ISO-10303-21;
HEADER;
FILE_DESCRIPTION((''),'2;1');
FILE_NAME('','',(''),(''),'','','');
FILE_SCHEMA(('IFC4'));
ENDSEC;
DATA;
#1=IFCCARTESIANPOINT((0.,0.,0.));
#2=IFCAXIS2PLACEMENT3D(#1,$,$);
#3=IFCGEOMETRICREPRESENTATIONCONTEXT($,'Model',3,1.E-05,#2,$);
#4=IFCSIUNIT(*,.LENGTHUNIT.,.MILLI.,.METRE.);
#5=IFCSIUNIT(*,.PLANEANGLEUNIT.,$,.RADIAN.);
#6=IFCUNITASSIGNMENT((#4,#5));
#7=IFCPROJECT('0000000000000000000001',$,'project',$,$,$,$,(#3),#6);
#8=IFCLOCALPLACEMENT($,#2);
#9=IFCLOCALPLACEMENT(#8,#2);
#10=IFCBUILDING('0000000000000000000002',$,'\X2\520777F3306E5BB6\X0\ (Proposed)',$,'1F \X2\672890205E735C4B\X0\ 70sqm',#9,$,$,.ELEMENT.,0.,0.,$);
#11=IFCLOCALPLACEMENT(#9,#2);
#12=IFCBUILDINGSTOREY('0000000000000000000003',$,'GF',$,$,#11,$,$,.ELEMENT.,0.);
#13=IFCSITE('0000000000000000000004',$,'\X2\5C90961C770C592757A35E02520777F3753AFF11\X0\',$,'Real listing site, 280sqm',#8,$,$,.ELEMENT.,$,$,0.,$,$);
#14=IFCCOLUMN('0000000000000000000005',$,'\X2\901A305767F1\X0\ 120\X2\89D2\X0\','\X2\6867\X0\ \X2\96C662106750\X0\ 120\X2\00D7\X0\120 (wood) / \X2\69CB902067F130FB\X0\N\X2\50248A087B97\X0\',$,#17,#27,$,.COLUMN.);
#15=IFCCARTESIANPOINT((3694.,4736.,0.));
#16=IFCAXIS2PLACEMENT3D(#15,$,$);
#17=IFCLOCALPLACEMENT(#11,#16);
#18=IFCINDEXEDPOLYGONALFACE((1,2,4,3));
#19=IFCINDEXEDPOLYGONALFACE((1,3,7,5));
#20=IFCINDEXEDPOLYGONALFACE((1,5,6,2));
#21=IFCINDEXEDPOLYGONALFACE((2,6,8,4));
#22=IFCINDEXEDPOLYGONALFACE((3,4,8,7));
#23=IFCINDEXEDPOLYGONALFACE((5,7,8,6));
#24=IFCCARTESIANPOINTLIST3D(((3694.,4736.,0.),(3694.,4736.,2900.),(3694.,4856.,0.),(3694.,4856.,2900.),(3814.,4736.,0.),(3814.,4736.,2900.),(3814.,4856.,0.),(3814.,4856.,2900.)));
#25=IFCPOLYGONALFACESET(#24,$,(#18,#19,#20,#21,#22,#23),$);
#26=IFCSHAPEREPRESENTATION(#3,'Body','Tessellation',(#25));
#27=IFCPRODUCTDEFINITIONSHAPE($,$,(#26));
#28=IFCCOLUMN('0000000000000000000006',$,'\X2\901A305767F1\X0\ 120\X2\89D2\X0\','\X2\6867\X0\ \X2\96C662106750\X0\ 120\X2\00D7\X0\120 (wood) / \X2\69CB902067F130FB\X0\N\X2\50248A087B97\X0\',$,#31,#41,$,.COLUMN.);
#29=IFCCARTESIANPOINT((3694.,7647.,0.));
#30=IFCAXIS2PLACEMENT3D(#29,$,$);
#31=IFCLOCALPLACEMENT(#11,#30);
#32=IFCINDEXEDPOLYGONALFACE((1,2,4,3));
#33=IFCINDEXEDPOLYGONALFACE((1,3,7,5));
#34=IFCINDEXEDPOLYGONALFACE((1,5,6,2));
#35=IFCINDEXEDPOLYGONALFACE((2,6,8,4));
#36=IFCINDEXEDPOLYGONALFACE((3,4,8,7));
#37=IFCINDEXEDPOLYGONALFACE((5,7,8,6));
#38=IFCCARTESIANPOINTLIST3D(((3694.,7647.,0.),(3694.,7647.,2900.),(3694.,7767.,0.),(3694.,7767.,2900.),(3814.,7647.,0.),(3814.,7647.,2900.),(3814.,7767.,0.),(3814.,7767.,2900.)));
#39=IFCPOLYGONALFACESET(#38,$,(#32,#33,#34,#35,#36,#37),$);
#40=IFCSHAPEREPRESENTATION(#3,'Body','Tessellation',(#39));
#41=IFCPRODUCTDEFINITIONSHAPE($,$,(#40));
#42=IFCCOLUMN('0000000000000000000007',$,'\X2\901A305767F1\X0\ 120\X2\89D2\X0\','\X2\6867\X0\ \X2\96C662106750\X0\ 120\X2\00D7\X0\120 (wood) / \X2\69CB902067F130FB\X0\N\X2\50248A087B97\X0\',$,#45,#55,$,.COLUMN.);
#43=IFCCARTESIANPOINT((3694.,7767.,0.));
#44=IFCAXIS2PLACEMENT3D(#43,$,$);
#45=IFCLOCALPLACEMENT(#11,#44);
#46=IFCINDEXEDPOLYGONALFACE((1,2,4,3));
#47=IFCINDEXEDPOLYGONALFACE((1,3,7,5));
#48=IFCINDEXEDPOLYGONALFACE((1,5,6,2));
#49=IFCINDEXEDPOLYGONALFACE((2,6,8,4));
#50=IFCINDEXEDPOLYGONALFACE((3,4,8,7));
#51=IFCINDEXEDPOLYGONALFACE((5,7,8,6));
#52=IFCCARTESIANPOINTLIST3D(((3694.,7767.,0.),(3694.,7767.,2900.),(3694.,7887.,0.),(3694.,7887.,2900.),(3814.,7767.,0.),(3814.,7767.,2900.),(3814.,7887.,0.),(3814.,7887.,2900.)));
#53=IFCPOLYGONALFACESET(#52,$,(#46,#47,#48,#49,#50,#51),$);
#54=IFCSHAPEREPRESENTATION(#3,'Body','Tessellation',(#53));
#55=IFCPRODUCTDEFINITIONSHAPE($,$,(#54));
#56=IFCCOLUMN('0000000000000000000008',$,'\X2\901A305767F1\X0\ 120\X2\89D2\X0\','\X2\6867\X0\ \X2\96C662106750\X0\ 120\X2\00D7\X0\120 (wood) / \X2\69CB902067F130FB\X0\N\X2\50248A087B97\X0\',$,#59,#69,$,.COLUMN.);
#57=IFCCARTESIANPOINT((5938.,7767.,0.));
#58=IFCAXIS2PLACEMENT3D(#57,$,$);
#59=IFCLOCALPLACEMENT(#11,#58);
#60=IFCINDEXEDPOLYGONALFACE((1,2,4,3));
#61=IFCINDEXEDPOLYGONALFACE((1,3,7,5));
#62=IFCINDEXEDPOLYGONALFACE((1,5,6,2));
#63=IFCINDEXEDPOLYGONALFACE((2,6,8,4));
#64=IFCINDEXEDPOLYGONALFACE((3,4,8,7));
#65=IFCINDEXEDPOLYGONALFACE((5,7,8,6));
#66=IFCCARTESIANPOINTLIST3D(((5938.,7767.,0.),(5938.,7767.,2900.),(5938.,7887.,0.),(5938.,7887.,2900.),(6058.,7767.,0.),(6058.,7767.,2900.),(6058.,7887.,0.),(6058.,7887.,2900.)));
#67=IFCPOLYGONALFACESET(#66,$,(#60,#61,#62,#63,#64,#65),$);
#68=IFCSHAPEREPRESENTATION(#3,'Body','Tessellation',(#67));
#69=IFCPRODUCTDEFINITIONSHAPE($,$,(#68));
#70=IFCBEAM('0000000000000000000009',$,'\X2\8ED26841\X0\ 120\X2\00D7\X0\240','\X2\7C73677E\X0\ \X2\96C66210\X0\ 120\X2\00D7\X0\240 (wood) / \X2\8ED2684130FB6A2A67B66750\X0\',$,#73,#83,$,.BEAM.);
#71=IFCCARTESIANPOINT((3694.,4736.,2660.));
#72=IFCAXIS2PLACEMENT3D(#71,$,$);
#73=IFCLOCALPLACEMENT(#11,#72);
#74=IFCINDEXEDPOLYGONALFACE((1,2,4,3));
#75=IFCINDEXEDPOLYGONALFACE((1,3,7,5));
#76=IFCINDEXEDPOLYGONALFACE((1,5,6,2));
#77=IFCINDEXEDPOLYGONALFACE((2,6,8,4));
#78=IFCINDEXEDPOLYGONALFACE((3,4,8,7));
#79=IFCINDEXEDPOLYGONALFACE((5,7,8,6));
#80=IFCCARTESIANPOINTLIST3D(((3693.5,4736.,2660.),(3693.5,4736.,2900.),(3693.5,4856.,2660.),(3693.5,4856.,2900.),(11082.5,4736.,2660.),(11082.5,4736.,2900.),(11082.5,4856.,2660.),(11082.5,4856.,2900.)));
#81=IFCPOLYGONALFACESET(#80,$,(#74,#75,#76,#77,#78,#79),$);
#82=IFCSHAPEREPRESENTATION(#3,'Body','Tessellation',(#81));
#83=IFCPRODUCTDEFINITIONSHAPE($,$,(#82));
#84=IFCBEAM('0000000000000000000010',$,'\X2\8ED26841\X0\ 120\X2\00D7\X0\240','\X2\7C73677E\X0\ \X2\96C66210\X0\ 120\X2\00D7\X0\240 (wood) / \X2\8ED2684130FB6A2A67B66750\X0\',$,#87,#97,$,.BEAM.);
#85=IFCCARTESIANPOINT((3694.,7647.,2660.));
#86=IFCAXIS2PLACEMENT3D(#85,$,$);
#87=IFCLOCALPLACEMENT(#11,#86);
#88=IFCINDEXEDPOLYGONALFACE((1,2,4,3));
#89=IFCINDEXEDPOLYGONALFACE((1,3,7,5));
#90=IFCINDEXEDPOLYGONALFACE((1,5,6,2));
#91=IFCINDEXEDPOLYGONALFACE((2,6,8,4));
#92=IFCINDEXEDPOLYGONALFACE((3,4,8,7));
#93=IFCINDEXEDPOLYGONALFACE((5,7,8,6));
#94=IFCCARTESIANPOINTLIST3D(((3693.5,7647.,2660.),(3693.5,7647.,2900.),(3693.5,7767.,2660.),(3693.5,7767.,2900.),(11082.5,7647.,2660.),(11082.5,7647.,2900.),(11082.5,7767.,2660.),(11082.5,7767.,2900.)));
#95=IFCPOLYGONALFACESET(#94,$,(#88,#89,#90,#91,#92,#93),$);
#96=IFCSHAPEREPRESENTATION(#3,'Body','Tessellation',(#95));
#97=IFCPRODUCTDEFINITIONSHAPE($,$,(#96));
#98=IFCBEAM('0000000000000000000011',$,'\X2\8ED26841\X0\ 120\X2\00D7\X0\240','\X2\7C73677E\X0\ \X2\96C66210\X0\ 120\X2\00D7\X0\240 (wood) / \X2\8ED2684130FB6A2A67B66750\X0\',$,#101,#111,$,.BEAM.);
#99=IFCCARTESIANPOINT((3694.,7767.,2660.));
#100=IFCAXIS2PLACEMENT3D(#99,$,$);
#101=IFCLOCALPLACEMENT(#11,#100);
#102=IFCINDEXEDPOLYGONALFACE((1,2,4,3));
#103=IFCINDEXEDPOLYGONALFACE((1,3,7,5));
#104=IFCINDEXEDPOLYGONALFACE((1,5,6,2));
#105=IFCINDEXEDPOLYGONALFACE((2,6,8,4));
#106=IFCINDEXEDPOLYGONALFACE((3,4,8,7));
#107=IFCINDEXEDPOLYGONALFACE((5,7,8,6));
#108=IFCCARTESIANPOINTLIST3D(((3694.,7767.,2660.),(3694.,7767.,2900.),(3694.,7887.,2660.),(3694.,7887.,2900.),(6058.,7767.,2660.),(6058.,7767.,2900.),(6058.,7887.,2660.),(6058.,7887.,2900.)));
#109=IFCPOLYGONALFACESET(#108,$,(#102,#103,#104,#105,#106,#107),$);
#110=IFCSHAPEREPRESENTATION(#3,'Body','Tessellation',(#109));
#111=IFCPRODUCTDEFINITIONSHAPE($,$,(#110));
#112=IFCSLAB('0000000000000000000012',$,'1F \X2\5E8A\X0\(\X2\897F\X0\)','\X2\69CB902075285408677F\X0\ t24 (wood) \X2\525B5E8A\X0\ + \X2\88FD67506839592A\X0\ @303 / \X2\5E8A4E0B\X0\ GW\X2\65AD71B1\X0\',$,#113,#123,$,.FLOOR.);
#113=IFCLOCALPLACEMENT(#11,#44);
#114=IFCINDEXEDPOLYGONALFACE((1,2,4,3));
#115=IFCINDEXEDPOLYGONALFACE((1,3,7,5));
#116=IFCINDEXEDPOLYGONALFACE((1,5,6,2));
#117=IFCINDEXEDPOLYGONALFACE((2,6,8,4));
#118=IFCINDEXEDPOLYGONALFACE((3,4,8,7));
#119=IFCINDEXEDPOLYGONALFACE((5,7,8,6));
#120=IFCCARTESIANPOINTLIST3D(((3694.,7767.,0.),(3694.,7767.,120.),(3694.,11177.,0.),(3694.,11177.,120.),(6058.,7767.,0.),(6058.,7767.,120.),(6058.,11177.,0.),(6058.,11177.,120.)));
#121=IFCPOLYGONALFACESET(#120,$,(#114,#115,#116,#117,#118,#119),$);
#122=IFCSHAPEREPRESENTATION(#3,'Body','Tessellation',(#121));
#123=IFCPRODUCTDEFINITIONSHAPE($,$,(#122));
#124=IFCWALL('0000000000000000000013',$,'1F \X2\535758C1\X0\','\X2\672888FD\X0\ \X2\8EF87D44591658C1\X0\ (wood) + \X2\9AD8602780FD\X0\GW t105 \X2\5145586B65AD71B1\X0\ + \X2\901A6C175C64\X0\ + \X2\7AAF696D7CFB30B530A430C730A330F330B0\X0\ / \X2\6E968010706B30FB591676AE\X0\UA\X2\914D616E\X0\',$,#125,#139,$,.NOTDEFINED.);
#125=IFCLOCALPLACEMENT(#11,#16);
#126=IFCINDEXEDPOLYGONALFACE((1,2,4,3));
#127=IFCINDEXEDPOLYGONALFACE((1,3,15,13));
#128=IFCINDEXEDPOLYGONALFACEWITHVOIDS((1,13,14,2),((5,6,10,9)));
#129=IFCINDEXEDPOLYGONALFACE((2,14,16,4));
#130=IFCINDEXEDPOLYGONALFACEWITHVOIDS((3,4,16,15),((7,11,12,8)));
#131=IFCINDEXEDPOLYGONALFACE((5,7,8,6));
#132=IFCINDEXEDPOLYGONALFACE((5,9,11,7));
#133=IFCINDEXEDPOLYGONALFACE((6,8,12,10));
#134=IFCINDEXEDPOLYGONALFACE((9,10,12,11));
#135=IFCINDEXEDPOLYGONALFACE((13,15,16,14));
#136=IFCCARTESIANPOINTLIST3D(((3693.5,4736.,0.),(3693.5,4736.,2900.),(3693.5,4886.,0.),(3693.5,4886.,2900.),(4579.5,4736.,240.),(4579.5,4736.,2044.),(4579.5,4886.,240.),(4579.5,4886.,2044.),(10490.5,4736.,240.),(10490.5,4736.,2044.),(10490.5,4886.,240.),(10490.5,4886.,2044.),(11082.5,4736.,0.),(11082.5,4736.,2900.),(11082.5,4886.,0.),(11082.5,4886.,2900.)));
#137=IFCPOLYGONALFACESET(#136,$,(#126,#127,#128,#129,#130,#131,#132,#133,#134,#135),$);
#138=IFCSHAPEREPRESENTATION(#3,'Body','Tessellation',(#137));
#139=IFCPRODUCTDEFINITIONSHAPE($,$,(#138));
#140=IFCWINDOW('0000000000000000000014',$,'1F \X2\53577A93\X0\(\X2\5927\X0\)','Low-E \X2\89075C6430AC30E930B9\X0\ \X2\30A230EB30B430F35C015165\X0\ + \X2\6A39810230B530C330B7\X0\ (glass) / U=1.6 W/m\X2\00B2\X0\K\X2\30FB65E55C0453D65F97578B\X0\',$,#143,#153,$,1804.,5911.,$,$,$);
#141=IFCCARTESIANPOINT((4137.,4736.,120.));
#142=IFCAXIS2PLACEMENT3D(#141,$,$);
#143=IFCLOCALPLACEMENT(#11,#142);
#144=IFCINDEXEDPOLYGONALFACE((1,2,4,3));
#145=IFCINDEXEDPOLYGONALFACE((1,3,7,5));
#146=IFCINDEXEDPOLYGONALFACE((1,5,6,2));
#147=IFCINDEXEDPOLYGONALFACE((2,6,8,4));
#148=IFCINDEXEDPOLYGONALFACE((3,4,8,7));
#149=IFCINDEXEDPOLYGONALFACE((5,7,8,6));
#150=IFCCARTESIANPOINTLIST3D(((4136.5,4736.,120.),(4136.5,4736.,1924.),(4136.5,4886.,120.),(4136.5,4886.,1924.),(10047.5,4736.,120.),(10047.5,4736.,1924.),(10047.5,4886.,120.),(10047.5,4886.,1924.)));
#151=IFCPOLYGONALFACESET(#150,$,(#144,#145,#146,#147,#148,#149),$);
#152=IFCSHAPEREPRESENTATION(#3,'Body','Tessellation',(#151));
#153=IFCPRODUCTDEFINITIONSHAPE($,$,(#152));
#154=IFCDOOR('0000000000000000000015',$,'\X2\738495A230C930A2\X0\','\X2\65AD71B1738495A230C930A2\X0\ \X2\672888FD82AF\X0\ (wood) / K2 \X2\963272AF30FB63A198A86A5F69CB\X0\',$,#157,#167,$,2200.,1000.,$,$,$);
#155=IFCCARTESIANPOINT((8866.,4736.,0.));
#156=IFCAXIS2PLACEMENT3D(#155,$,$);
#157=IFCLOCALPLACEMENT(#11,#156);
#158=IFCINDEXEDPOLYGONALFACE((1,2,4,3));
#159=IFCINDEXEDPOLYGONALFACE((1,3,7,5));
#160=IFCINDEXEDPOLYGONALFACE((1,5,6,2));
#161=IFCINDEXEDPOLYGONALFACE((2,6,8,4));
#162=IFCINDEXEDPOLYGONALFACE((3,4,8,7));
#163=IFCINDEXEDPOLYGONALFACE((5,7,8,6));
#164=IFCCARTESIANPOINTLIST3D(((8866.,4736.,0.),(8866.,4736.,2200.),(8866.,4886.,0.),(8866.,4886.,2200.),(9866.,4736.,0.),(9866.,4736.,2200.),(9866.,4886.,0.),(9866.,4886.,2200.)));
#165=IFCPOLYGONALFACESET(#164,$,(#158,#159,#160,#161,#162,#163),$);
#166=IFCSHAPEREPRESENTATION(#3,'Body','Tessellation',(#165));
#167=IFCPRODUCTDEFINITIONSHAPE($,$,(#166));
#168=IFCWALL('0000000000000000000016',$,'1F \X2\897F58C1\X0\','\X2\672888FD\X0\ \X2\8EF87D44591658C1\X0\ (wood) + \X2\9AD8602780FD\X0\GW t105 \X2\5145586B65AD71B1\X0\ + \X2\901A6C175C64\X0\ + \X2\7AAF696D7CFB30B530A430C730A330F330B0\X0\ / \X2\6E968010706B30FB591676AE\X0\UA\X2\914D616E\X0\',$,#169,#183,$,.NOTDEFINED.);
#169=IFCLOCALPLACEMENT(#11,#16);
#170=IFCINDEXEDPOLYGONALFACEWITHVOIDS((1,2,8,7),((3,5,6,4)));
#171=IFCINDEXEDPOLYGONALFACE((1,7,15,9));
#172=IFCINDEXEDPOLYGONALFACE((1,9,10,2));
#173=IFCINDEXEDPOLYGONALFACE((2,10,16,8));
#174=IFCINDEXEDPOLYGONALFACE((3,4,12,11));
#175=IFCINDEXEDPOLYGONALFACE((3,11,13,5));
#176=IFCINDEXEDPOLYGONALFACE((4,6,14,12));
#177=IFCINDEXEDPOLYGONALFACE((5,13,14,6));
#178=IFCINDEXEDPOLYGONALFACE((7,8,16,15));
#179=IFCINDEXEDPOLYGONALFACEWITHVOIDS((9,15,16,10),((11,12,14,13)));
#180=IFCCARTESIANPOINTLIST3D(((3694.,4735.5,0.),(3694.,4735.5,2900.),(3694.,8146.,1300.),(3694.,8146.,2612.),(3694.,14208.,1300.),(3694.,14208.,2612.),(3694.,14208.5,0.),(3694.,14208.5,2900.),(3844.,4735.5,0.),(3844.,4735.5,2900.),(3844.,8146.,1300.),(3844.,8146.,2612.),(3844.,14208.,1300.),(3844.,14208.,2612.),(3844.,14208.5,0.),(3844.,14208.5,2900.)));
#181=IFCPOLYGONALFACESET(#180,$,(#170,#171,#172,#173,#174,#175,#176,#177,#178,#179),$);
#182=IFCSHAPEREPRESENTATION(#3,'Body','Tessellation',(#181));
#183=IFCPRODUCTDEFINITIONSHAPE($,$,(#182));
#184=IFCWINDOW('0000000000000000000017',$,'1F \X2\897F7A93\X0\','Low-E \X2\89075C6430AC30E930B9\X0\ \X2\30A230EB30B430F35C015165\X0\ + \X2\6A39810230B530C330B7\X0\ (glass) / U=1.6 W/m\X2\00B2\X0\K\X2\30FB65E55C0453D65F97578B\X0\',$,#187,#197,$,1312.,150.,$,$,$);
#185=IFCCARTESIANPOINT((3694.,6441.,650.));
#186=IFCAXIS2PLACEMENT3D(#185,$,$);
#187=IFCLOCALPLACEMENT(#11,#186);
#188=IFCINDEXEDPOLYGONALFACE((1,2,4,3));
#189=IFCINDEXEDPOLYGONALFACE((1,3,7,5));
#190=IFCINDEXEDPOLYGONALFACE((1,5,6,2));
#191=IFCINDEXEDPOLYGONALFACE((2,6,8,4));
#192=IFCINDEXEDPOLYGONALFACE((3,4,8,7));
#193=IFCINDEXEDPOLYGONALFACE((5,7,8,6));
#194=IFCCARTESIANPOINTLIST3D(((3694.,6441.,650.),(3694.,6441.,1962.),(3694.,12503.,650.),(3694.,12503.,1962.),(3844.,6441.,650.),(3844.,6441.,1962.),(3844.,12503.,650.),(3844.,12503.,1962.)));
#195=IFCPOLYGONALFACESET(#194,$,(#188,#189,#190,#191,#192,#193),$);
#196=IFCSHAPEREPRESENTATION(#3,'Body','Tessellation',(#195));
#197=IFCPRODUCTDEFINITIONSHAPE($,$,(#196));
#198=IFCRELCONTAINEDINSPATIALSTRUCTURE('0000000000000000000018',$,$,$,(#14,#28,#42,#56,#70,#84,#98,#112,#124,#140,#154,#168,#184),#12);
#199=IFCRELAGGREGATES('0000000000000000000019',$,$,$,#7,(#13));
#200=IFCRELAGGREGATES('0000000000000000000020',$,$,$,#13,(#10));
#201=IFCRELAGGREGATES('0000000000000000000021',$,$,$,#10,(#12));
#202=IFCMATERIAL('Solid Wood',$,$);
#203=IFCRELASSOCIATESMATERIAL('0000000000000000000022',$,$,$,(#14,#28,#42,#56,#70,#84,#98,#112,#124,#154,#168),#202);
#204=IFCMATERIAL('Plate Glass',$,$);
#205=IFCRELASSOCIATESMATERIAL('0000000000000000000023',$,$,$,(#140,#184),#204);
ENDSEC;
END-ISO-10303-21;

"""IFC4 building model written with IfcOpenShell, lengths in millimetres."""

from ifc_helpers import new_model, si_unit, frame, frame_2d, origin, place, context, project, spatial, rectangle, extrude, material, element, fill, save


model = new_model("IFC4")

# Units and contexts
model_context = context("Model", 3, precision=1e-05, world=origin())
ifc_project = project(units=[si_unit("LENGTHUNIT", "METRE", prefix="MILLI"), si_unit("PLANEANGLEUNIT", "RADIAN")], contexts=[model_context])

# Site, building, storey
site_placement = place(None, origin())
site = spatial("IfcSite", under=ifc_project, at=site_placement, Name="岐阜県大垣市切石町１", ObjectType="Real listing site, 280sqm", CompositionType="ELEMENT", RefElevation=0.0)
building_placement = place(site_placement, origin())
building = spatial("IfcBuilding", under=site, at=building_placement, Name="切石の家 (Proposed)", ObjectType="1F 木造平屋 70sqm", CompositionType="ELEMENT", ElevationOfRefHeight=0.0, ElevationOfTerrain=0.0)
storey_placement = place(building_placement, origin())
storey = spatial("IfcBuildingStorey", under=building, at=storey_placement, Name="GF", CompositionType="ELEMENT", Elevation=0.0)

# Columns
ifc_material_1 = material(Name="Solid Wood")
column_1_placement = place(storey_placement, frame((3694.0, 4736.0, 0.0)))
element("IfcColumn", 1, at=column_1_placement, inside=storey, material=ifc_material_1, Name="通し柱 120角", Description="桧 集成材 120×120 (wood) / 構造柱・N値計算", PredefinedType="COLUMN", context=model_context, shape_type="SweptSolid", body=[
    extrude(rectangle(XDim=120.0, YDim=120.0, at=frame_2d((60.0, 60.0))), frame((3694.0, 4736.0, 0.0)), (0.0, 0.0, 1.0), 2900.0),
])
column_2_placement = place(storey_placement, frame((3694.0, 7647.0, 0.0)))
element("IfcColumn", 2, at=column_2_placement, inside=storey, material=ifc_material_1, Name="通し柱 120角", Description="桧 集成材 120×120 (wood) / 構造柱・N値計算", PredefinedType="COLUMN", context=model_context, shape_type="SweptSolid", body=[
    extrude(rectangle(XDim=120.0, YDim=120.0, at=frame_2d((60.0, 60.0))), frame((3694.0, 7647.0, 0.0)), (0.0, 0.0, 1.0), 2900.0),
])
column_3_placement = place(storey_placement, frame((3694.0, 7767.0, 0.0)))
element("IfcColumn", 3, at=column_3_placement, inside=storey, material=ifc_material_1, Name="通し柱 120角", Description="桧 集成材 120×120 (wood) / 構造柱・N値計算", PredefinedType="COLUMN", context=model_context, shape_type="SweptSolid", body=[
    extrude(rectangle(XDim=120.0, YDim=120.0, at=frame_2d((60.0, 60.0))), frame((3694.0, 7767.0, 0.0)), (0.0, 0.0, 1.0), 2900.0),
])
column_4_placement = place(storey_placement, frame((5938.0, 7767.0, 0.0)))
element("IfcColumn", 4, at=column_4_placement, inside=storey, material=ifc_material_1, Name="通し柱 120角", Description="桧 集成材 120×120 (wood) / 構造柱・N値計算", PredefinedType="COLUMN", context=model_context, shape_type="SweptSolid", body=[
    extrude(rectangle(XDim=120.0, YDim=120.0, at=frame_2d((60.0, 60.0))), frame((5938.0, 7767.0, 0.0)), (0.0, 0.0, 1.0), 2900.0),
])

# Beams
beam_1_placement = place(storey_placement, frame((3694.0, 4736.0, 2660.0)))
element("IfcBeam", 5, at=beam_1_placement, inside=storey, material=ifc_material_1, Name="軒桁 120×240", Description="米松 集成 120×240 (wood) / 軒桁・横架材", PredefinedType="BEAM", context=model_context, shape_type="SweptSolid", body=[
    extrude(rectangle(XDim=7389.0, YDim=120.0, at=frame_2d((3694.0, 60.0))), frame((3694.0, 4736.0, 2660.0)), (0.0, 0.0, 1.0), 240.0),
])
beam_2_placement = place(storey_placement, frame((3694.0, 7647.0, 2660.0)))
element("IfcBeam", 6, at=beam_2_placement, inside=storey, material=ifc_material_1, Name="軒桁 120×240", Description="米松 集成 120×240 (wood) / 軒桁・横架材", PredefinedType="BEAM", context=model_context, shape_type="SweptSolid", body=[
    extrude(rectangle(XDim=7389.0, YDim=120.0, at=frame_2d((3694.0, 60.0))), frame((3694.0, 7647.0, 2660.0)), (0.0, 0.0, 1.0), 240.0),
])
beam_3_placement = place(storey_placement, frame((3694.0, 7767.0, 2660.0)))
element("IfcBeam", 7, at=beam_3_placement, inside=storey, material=ifc_material_1, Name="軒桁 120×240", Description="米松 集成 120×240 (wood) / 軒桁・横架材", PredefinedType="BEAM", context=model_context, shape_type="SweptSolid", body=[
    extrude(rectangle(XDim=2364.0, YDim=120.0, at=frame_2d((1182.0, 60.0))), frame((3694.0, 7767.0, 2660.0)), (0.0, 0.0, 1.0), 240.0),
])

# Slab
slab_1_placement = place(storey_placement, frame((3694.0, 7767.0, 0.0)))
element("IfcSlab", 8, at=slab_1_placement, inside=storey, material=ifc_material_1, Name="1F 床(西)", Description="構造用合板 t24 (wood) 剛床 + 製材根太 @303 / 床下 GW断熱", PredefinedType="FLOOR", context=model_context, shape_type="SweptSolid", body=[
    extrude(rectangle(XDim=2364.0, YDim=3410.0, at=frame_2d((1182.0, 1705.0))), frame((3694.0, 7767.0, 0.0)), (0.0, 0.0, 1.0), 120.0),
])

# Wall, openings, window, door
wall_1_placement = place(storey_placement, frame((3694.0, 4736.0, 0.0)))
wall_1 = element("IfcWall", 9, at=wall_1_placement, inside=storey, material=ifc_material_1, Name="1F 南壁", Description="木製 軸組外壁 (wood) + 高性能GW t105 充填断熱 + 通気層 + 窯業系サイディング / 準耐火・外皮UA配慮", PredefinedType="NOTDEFINED", context=model_context, shape_type="SweptSolid", body=[
    extrude(rectangle(XDim=7389.0, YDim=150.0, at=frame_2d((3694.0, 75.0))), frame((3694.0, 4736.0, 0.0)), (0.0, 0.0, 1.0), 2900.0),
])
opening_1_placement = place(storey_placement, frame((4137.0, 4736.0, 120.0)))
opening_1 = element("IfcOpeningElement", 10, at=opening_1_placement, cuts=wall_1, PredefinedType="NOTDEFINED", context=model_context, shape_type="SweptSolid", body=[
    extrude(rectangle(XDim=5911.0, YDim=150.0, at=frame_2d((2955.0, 75.0))), frame((4137.0, 4736.0, 120.0)), (0.0, 0.0, 1.0), 1804.0),
])
opening_2_placement = place(storey_placement, frame((8866.0, 4736.0, 0.0)))
opening_2 = element("IfcOpeningElement", 11, at=opening_2_placement, cuts=wall_1, PredefinedType="NOTDEFINED", context=model_context, shape_type="SweptSolid", body=[
    extrude(rectangle(XDim=1000.0, YDim=150.0, at=frame_2d((500.0, 75.0))), frame((8866.0, 4736.0, 0.0)), (0.0, 0.0, 1.0), 2200.0),
])
ifc_material_2 = material(Name="Plate Glass")
window_1_placement = place(storey_placement, frame((4137.0, 4736.0, 120.0)))
window_1 = element("IfcWindow", 12, at=window_1_placement, inside=storey, material=ifc_material_2, Name="1F 南窓(大)", Description="Low-E 複層ガラス アルゴン封入 + 樹脂サッシ (glass) / U=1.6 W/m²K・日射取得型", OverallHeight=1804.0, OverallWidth=5911.0, context=model_context, shape_type="SweptSolid", body=[
    extrude(rectangle(XDim=5911.0, YDim=150.0, at=frame_2d((2955.0, 75.0))), frame((4137.0, 4736.0, 120.0)), (0.0, 0.0, 1.0), 1804.0),
])
fill(opening_1, window_1)
door_placement = place(storey_placement, frame((8866.0, 4736.0, 0.0)))
door = element("IfcDoor", 13, at=door_placement, inside=storey, material=ifc_material_1, Name="玄関ドア", Description="断熱玄関ドア 木製芯 (wood) / K2 防犯・採風機構", OverallHeight=2200.0, OverallWidth=1000.0, context=model_context, shape_type="SweptSolid", body=[
    extrude(rectangle(XDim=1000.0, YDim=150.0, at=frame_2d((500.0, 75.0))), frame((8866.0, 4736.0, 0.0)), (0.0, 0.0, 1.0), 2200.0),
])
fill(opening_2, door)

# Wall, opening, window
wall_2_placement = place(storey_placement, frame((3694.0, 4736.0, 0.0)))
wall_2 = element("IfcWall", 14, at=wall_2_placement, inside=storey, material=ifc_material_1, Name="1F 西壁", Description="木製 軸組外壁 (wood) + 高性能GW t105 充填断熱 + 通気層 + 窯業系サイディング / 準耐火・外皮UA配慮", PredefinedType="NOTDEFINED", context=model_context, shape_type="SweptSolid", body=[
    extrude(rectangle(XDim=150.0, YDim=9473.0, at=frame_2d((75.0, 4736.0))), frame((3694.0, 4736.0, 0.0)), (0.0, 0.0, 1.0), 2900.0),
])
opening_3_placement = place(storey_placement, frame((3694.0, 6441.0, 650.0)))
opening_3 = element("IfcOpeningElement", 15, at=opening_3_placement, cuts=wall_2, PredefinedType="NOTDEFINED", context=model_context, shape_type="SweptSolid", body=[
    extrude(rectangle(XDim=150.0, YDim=6062.0, at=frame_2d((75.0, 3031.0))), frame((3694.0, 6441.0, 650.0)), (0.0, 0.0, 1.0), 1312.0),
])
window_2_placement = place(storey_placement, frame((3694.0, 6441.0, 650.0)))
window_2 = element("IfcWindow", 16, at=window_2_placement, inside=storey, material=ifc_material_2, Name="1F 西窓", Description="Low-E 複層ガラス アルゴン封入 + 樹脂サッシ (glass) / U=1.6 W/m²K・日射取得型", OverallHeight=1312.0, OverallWidth=150.0, context=model_context, shape_type="SweptSolid", body=[
    extrude(rectangle(XDim=150.0, YDim=6062.0, at=frame_2d((75.0, 3031.0))), frame((3694.0, 6441.0, 650.0)), (0.0, 0.0, 1.0), 1312.0),
])
fill(opening_3, window_2)

save(model, "model.ifc")
